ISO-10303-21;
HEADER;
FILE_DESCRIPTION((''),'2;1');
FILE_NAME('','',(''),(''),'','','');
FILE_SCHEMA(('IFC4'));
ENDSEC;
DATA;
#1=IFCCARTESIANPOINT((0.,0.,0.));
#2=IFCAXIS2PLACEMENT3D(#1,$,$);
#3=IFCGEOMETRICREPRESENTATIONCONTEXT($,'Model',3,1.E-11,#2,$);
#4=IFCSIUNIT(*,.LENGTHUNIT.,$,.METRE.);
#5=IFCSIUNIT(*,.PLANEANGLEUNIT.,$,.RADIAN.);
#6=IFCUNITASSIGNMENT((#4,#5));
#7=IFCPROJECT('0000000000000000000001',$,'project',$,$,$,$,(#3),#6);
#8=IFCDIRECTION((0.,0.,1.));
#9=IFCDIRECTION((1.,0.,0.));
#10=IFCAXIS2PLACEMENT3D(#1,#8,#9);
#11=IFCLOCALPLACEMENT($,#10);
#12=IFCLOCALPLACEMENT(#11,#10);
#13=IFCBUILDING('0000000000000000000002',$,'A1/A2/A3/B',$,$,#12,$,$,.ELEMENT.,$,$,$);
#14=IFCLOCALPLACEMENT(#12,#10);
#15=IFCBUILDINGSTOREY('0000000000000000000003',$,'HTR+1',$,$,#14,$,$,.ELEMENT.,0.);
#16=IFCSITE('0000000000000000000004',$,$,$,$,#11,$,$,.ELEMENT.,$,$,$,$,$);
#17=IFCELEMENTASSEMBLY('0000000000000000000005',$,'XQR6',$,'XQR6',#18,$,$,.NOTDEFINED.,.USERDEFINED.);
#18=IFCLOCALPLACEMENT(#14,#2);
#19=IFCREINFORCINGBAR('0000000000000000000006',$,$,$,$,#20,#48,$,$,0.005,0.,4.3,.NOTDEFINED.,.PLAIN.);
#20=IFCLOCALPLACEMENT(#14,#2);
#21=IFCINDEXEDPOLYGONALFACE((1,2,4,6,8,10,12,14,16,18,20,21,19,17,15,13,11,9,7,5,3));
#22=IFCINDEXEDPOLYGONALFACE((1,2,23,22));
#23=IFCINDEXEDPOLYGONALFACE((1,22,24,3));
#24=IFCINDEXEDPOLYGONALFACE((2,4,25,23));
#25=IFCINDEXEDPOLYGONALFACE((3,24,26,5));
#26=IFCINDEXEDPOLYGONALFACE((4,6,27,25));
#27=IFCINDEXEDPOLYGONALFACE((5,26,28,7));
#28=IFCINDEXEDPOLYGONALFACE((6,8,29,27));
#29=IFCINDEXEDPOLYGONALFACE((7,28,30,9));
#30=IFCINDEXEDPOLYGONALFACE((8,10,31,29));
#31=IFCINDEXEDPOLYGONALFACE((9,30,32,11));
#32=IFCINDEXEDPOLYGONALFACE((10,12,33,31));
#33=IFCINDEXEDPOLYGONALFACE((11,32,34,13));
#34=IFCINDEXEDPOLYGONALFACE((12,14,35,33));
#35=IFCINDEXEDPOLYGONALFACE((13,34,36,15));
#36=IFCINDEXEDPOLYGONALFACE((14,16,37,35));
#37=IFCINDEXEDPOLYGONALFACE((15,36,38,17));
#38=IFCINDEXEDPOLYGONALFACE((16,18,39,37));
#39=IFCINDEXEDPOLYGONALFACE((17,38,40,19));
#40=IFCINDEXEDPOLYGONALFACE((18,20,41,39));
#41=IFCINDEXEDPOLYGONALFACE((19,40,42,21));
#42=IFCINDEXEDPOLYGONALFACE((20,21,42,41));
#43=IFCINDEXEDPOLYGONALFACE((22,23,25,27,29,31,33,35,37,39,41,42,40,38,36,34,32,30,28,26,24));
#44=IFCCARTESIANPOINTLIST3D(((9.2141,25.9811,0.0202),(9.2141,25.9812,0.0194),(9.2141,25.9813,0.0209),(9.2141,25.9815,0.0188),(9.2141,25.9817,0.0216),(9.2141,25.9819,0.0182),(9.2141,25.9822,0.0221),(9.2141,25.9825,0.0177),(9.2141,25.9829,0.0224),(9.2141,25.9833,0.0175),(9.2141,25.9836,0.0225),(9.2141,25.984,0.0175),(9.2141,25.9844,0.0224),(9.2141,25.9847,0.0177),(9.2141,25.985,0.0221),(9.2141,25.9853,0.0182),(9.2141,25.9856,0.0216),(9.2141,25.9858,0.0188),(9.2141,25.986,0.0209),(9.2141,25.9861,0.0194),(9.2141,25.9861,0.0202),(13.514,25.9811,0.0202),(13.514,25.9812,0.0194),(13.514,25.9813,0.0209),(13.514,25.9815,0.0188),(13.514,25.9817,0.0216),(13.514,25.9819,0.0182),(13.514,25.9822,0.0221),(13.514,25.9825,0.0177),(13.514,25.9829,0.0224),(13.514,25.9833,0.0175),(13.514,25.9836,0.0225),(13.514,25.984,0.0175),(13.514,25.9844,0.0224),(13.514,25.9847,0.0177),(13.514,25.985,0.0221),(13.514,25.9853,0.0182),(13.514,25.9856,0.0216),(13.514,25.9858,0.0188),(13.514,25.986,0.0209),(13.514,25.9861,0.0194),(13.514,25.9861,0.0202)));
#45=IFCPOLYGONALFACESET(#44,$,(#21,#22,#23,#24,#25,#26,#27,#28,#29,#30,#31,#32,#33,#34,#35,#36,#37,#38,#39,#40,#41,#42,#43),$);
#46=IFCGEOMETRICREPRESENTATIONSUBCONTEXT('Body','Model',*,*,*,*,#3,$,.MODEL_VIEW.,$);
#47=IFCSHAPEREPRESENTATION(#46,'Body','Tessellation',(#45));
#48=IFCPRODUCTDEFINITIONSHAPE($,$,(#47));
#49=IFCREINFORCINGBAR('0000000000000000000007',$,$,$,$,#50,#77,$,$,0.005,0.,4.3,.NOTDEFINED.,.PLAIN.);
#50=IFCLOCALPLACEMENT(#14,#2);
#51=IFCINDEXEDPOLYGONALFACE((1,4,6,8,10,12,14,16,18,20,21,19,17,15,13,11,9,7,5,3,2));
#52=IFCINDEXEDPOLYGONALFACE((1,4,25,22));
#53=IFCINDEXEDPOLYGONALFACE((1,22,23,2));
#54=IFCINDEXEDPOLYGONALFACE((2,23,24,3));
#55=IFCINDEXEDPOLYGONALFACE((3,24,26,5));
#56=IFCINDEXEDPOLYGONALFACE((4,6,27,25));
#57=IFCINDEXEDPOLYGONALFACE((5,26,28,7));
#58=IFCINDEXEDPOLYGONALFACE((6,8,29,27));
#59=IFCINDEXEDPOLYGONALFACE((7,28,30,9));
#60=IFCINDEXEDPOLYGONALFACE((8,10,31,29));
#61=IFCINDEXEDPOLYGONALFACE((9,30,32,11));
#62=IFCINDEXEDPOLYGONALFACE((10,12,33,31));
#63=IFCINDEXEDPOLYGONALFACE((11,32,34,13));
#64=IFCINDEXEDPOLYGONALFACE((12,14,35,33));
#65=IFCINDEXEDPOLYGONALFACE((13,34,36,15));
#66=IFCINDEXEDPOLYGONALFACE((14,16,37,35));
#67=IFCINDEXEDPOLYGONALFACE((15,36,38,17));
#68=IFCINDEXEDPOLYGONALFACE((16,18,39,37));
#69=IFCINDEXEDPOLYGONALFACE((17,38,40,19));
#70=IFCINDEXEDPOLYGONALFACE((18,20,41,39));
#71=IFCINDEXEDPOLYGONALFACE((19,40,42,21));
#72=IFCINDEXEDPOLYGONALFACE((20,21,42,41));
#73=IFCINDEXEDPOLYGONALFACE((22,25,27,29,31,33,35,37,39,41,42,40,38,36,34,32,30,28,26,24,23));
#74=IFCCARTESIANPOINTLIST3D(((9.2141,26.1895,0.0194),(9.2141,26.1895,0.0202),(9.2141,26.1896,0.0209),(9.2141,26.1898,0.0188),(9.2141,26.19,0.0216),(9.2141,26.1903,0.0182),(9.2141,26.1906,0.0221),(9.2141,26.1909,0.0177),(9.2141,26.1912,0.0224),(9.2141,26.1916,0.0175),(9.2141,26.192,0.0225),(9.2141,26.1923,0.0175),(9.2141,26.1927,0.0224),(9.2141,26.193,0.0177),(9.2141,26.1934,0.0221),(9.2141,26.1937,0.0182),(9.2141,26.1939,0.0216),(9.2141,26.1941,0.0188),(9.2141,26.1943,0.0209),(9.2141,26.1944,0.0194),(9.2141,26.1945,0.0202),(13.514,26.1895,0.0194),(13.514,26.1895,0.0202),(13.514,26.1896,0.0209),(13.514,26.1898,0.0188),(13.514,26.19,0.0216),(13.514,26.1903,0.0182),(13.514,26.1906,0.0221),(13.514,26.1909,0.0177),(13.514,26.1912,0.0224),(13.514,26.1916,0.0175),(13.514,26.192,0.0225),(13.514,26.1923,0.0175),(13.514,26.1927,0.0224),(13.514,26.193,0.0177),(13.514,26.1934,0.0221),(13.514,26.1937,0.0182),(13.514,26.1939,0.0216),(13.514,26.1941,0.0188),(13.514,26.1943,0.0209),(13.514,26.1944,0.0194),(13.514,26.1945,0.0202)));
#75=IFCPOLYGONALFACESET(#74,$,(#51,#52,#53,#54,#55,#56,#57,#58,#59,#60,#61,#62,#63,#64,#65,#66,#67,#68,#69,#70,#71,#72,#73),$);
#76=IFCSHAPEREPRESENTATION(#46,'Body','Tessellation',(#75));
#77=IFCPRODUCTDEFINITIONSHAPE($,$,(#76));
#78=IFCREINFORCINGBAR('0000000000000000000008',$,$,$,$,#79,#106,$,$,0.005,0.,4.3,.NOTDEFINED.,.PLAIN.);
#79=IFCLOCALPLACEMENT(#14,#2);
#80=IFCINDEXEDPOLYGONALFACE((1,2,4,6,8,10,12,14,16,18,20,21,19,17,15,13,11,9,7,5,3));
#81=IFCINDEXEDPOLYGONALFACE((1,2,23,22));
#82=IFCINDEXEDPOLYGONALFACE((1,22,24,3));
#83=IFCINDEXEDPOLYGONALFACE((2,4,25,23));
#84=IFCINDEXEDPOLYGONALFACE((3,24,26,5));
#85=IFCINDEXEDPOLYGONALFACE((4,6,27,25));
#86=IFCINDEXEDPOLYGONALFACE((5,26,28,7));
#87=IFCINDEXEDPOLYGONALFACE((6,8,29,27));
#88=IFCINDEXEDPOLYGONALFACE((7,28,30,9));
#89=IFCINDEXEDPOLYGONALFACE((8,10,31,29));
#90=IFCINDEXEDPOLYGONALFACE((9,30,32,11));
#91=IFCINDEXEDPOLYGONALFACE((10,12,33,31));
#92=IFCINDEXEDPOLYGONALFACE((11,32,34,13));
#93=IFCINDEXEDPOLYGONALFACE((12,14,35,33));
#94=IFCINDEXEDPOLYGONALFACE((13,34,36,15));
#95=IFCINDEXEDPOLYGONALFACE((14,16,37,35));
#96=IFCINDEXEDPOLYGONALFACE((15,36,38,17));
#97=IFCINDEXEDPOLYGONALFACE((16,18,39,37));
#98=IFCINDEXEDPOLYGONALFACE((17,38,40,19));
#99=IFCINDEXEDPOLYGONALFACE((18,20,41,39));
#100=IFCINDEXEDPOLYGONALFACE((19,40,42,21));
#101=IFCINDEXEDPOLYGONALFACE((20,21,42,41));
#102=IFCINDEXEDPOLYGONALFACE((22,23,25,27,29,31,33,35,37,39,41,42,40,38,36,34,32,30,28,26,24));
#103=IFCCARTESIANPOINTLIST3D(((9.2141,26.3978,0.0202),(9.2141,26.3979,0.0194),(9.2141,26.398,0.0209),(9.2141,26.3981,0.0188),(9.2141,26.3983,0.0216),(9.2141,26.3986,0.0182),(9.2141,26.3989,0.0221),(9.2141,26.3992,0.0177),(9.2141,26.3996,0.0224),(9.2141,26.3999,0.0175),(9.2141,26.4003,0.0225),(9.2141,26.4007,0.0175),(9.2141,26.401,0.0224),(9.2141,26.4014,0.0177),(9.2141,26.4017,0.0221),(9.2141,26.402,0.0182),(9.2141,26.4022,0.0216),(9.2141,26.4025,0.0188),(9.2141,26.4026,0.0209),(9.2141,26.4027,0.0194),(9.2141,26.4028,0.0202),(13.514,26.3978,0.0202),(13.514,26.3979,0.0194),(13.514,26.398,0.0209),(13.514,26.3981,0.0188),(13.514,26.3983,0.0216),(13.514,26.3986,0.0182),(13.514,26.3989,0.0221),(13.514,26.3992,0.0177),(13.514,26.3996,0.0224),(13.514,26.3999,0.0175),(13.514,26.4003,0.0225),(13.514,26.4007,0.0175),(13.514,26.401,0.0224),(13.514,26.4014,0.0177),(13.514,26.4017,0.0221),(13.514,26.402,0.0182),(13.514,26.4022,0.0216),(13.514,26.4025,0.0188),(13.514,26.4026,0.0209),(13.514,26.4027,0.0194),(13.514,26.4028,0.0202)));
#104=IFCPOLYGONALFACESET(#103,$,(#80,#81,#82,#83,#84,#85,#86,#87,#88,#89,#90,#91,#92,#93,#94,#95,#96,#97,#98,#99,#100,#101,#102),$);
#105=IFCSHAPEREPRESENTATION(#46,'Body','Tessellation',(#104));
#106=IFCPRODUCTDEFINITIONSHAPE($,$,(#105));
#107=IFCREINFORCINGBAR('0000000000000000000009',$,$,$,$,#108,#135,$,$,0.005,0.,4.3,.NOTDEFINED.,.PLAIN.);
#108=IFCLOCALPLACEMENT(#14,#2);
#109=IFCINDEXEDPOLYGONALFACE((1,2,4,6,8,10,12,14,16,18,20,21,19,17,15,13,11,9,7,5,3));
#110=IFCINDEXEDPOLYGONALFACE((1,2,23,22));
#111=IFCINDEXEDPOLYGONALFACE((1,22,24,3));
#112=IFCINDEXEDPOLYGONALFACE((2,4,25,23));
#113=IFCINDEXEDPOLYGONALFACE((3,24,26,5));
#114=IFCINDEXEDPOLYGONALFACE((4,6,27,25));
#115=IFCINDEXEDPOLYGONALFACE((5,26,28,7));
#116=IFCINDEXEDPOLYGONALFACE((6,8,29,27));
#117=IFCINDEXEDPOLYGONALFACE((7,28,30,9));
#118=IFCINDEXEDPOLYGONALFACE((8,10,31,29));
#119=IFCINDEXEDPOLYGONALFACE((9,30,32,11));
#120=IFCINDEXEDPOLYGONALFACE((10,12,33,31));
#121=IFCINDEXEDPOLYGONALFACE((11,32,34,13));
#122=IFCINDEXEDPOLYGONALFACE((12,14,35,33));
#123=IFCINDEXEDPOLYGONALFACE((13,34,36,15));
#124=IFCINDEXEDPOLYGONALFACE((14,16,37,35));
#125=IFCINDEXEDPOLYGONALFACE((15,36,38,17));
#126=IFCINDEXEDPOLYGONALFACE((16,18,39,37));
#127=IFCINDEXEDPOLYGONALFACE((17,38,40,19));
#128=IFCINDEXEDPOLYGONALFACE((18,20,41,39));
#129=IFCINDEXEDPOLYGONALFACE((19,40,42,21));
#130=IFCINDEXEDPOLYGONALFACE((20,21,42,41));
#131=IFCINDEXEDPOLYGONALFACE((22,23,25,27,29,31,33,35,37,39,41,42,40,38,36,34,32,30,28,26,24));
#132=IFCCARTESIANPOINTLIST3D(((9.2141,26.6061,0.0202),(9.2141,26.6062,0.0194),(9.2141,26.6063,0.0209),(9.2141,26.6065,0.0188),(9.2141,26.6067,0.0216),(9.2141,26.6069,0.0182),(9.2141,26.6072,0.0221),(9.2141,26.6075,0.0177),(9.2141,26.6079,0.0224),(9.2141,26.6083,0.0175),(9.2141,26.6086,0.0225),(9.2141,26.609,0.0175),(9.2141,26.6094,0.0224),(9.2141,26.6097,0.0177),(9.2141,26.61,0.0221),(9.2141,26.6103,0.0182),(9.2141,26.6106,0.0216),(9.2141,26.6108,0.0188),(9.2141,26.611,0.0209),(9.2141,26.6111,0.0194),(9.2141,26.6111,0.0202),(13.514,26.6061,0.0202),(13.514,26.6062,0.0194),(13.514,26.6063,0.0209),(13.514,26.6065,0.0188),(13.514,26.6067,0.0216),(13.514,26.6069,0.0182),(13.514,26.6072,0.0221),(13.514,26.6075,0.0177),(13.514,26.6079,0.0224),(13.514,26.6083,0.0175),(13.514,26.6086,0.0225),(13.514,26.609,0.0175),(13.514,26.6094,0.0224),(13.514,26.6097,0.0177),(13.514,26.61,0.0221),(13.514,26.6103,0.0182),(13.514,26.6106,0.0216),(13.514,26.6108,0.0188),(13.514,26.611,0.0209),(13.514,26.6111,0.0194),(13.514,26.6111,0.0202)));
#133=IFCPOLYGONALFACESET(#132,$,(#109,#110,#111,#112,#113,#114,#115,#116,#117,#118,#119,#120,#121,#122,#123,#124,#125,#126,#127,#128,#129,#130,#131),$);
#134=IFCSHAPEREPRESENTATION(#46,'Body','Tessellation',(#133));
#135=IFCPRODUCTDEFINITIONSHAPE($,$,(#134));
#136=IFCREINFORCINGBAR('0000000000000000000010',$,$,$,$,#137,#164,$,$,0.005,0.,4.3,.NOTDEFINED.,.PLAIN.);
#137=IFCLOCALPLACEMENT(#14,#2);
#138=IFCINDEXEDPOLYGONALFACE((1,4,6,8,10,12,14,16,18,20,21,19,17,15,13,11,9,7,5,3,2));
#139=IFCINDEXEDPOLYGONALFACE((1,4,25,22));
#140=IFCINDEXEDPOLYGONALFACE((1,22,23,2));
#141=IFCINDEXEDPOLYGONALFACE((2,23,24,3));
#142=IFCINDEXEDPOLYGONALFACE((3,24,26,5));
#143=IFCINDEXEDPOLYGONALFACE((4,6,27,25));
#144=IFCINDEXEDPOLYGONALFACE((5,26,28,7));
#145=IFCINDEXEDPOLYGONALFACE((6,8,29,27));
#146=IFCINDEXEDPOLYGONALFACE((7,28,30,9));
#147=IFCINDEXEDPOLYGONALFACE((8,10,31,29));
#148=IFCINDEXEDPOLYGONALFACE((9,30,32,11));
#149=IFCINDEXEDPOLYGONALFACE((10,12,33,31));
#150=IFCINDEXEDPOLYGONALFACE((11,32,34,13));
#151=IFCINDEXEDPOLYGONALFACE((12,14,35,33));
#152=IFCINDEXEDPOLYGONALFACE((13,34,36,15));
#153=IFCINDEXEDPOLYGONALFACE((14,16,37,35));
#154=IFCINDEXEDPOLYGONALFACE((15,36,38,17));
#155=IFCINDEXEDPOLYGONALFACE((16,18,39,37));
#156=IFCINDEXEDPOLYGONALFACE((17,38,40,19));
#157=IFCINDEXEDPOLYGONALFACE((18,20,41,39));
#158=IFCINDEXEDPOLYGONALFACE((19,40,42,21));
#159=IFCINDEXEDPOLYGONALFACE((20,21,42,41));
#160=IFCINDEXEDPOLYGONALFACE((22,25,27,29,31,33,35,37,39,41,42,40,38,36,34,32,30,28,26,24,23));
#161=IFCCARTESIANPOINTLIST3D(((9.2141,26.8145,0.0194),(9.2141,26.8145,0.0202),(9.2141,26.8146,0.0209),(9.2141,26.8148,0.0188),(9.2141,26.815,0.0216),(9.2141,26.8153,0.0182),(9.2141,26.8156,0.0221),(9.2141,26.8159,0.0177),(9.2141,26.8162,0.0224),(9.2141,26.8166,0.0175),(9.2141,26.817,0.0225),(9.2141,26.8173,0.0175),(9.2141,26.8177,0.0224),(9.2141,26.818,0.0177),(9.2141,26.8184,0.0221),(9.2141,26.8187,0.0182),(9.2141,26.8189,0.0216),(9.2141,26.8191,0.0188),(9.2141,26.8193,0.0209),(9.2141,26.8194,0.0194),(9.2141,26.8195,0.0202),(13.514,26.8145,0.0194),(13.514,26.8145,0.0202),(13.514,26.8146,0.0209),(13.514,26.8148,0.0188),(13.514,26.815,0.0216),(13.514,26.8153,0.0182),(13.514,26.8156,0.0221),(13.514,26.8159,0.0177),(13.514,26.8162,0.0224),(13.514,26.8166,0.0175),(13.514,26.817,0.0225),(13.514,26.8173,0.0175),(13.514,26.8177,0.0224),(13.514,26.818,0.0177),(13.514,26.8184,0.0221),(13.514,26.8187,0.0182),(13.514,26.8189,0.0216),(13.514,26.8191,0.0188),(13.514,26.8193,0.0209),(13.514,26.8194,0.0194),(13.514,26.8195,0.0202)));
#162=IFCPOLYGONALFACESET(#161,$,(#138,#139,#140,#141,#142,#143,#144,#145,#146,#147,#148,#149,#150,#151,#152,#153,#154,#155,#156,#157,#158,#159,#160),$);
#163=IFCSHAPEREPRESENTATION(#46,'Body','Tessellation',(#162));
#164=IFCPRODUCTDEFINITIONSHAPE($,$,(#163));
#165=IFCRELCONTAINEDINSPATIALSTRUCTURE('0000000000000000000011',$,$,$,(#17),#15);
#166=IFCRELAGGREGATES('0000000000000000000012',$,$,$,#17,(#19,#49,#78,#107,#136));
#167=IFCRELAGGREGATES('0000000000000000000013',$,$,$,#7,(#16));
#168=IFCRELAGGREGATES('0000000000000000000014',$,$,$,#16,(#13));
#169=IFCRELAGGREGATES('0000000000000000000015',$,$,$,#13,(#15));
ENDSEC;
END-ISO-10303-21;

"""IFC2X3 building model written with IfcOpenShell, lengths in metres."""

from ifc_helpers import new_model, entity, si_unit, origin, origin_with_axes, place, context, subcontext, project, spatial, shape, element, aggregate, save


model = new_model("IFC2X3")

# Units and contexts
model_context = context("Model", 3, precision=1e-11, world=origin())
body_context = subcontext(model_context, "Body", "Model", "MODEL_VIEW")
ifc_project = project(units=[si_unit("LENGTHUNIT", "METRE"), si_unit("PLANEANGLEUNIT", "RADIAN")], contexts=[model_context])

# Site, building, storey
site_placement = place(None, origin_with_axes())
site = spatial("IfcSite", under=ifc_project, at=site_placement, CompositionType="ELEMENT")
building_placement = place(site_placement, origin_with_axes())
building = spatial("IfcBuilding", under=site, at=building_placement, Name="A1/A2/A3/B", CompositionType="ELEMENT")
storey_placement = place(building_placement, origin_with_axes())
storey = spatial("IfcBuildingStorey", under=building, at=storey_placement, Name="HTR+1", CompositionType="ELEMENT", Elevation=0.0)

# Element assembly, reinforcing bars
assembly_1_placement = place(storey_placement, origin_with_axes())
assembly_1 = element("IfcElementAssembly", 1, at=assembly_1_placement, inside=storey, Name="XQR6", ObjectType="XQR6", AssemblyPlace="NOTDEFINED", PredefinedType="USERDEFINED")
reinforcing_bar_1_placement = place(assembly_1_placement, origin_with_axes())
reinforcing_bar_1 = element("IfcReinforcingBar", 2, at=reinforcing_bar_1_placement, BarLength=4.3, BarRole="NOTDEFINED", BarSurface="PLAIN", CrossSectionArea=0.0, NominalDiameter=0.005, shapes=[
    shape(body_context, "Body", "AdvancedSweptSolid", [entity("IfcSweptDiskSolid", entity("IfcPolyline", [entity("IfcCartesianPoint", [9.2141, 25.9836, 0.02]), entity("IfcCartesianPoint", [13.514, 25.9836, 0.02])]), 0.0025, None, 0.0, 4.3)]),
    shape(body_context, "Body", "AdvancedSweptSolid", [entity("IfcSweptDiskSolid", entity("IfcPolyline", [entity("IfcCartesianPoint", [9.2141, 25.9836, 0.02]), entity("IfcCartesianPoint", [13.514, 25.9836, 0.02])]), 0.0025, None, 0.0, 4.3)]),
])
reinforcing_bar_2_placement = place(assembly_1_placement, origin_with_axes())
reinforcing_bar_2 = element("IfcReinforcingBar", 3, at=reinforcing_bar_2_placement, BarLength=4.3, BarRole="NOTDEFINED", BarSurface="PLAIN", CrossSectionArea=0.0, NominalDiameter=0.005, shapes=[
    shape(body_context, "Body", "AdvancedSweptSolid", [entity("IfcSweptDiskSolid", entity("IfcPolyline", [entity("IfcCartesianPoint", [9.2141, 26.192, 0.02]), entity("IfcCartesianPoint", [13.514, 26.192, 0.02])]), 0.0025, None, 0.0, 4.3)]),
    shape(body_context, "Body", "AdvancedSweptSolid", [entity("IfcSweptDiskSolid", entity("IfcPolyline", [entity("IfcCartesianPoint", [9.2141, 26.192, 0.02]), entity("IfcCartesianPoint", [13.514, 26.192, 0.02])]), 0.0025, None, 0.0, 4.3)]),
])
reinforcing_bar_3_placement = place(assembly_1_placement, origin_with_axes())
reinforcing_bar_3 = element("IfcReinforcingBar", 4, at=reinforcing_bar_3_placement, BarLength=4.3, BarRole="NOTDEFINED", BarSurface="PLAIN", CrossSectionArea=0.0, NominalDiameter=0.005, shapes=[
    shape(body_context, "Body", "AdvancedSweptSolid", [entity("IfcSweptDiskSolid", entity("IfcPolyline", [entity("IfcCartesianPoint", [9.2141, 26.4003, 0.02]), entity("IfcCartesianPoint", [13.514, 26.4003, 0.02])]), 0.0025, None, 0.0, 4.3)]),
    shape(body_context, "Body", "AdvancedSweptSolid", [entity("IfcSweptDiskSolid", entity("IfcPolyline", [entity("IfcCartesianPoint", [9.2141, 26.4003, 0.02]), entity("IfcCartesianPoint", [13.514, 26.4003, 0.02])]), 0.0025, None, 0.0, 4.3)]),
])
reinforcing_bar_4_placement = place(assembly_1_placement, origin_with_axes())
reinforcing_bar_4 = element("IfcReinforcingBar", 5, at=reinforcing_bar_4_placement, BarLength=4.3, BarRole="NOTDEFINED", BarSurface="PLAIN", CrossSectionArea=0.0, NominalDiameter=0.005, shapes=[
    shape(body_context, "Body", "AdvancedSweptSolid", [entity("IfcSweptDiskSolid", entity("IfcPolyline", [entity("IfcCartesianPoint", [9.2141, 26.6086, 0.02]), entity("IfcCartesianPoint", [13.514, 26.6086, 0.02])]), 0.0025, None, 0.0, 4.3)]),
    shape(body_context, "Body", "AdvancedSweptSolid", [entity("IfcSweptDiskSolid", entity("IfcPolyline", [entity("IfcCartesianPoint", [9.2141, 26.6086, 0.02]), entity("IfcCartesianPoint", [13.514, 26.6086, 0.02])]), 0.0025, None, 0.0, 4.3)]),
])
reinforcing_bar_5_placement = place(assembly_1_placement, origin_with_axes())
reinforcing_bar_5 = element("IfcReinforcingBar", 6, at=reinforcing_bar_5_placement, BarLength=4.3, BarRole="NOTDEFINED", BarSurface="PLAIN", CrossSectionArea=0.0, NominalDiameter=0.005, shapes=[
    shape(body_context, "Body", "AdvancedSweptSolid", [entity("IfcSweptDiskSolid", entity("IfcPolyline", [entity("IfcCartesianPoint", [9.2141, 26.817, 0.02]), entity("IfcCartesianPoint", [13.514, 26.817, 0.02])]), 0.0025, None, 0.0, 4.3)]),
    shape(body_context, "Body", "AdvancedSweptSolid", [entity("IfcSweptDiskSolid", entity("IfcPolyline", [entity("IfcCartesianPoint", [9.2141, 26.817, 0.02]), entity("IfcCartesianPoint", [13.514, 26.817, 0.02])]), 0.0025, None, 0.0, 4.3)]),
])
aggregate(assembly_1, [reinforcing_bar_1, reinforcing_bar_2, reinforcing_bar_3, reinforcing_bar_4, reinforcing_bar_5])

save(model, "model.ifc")
